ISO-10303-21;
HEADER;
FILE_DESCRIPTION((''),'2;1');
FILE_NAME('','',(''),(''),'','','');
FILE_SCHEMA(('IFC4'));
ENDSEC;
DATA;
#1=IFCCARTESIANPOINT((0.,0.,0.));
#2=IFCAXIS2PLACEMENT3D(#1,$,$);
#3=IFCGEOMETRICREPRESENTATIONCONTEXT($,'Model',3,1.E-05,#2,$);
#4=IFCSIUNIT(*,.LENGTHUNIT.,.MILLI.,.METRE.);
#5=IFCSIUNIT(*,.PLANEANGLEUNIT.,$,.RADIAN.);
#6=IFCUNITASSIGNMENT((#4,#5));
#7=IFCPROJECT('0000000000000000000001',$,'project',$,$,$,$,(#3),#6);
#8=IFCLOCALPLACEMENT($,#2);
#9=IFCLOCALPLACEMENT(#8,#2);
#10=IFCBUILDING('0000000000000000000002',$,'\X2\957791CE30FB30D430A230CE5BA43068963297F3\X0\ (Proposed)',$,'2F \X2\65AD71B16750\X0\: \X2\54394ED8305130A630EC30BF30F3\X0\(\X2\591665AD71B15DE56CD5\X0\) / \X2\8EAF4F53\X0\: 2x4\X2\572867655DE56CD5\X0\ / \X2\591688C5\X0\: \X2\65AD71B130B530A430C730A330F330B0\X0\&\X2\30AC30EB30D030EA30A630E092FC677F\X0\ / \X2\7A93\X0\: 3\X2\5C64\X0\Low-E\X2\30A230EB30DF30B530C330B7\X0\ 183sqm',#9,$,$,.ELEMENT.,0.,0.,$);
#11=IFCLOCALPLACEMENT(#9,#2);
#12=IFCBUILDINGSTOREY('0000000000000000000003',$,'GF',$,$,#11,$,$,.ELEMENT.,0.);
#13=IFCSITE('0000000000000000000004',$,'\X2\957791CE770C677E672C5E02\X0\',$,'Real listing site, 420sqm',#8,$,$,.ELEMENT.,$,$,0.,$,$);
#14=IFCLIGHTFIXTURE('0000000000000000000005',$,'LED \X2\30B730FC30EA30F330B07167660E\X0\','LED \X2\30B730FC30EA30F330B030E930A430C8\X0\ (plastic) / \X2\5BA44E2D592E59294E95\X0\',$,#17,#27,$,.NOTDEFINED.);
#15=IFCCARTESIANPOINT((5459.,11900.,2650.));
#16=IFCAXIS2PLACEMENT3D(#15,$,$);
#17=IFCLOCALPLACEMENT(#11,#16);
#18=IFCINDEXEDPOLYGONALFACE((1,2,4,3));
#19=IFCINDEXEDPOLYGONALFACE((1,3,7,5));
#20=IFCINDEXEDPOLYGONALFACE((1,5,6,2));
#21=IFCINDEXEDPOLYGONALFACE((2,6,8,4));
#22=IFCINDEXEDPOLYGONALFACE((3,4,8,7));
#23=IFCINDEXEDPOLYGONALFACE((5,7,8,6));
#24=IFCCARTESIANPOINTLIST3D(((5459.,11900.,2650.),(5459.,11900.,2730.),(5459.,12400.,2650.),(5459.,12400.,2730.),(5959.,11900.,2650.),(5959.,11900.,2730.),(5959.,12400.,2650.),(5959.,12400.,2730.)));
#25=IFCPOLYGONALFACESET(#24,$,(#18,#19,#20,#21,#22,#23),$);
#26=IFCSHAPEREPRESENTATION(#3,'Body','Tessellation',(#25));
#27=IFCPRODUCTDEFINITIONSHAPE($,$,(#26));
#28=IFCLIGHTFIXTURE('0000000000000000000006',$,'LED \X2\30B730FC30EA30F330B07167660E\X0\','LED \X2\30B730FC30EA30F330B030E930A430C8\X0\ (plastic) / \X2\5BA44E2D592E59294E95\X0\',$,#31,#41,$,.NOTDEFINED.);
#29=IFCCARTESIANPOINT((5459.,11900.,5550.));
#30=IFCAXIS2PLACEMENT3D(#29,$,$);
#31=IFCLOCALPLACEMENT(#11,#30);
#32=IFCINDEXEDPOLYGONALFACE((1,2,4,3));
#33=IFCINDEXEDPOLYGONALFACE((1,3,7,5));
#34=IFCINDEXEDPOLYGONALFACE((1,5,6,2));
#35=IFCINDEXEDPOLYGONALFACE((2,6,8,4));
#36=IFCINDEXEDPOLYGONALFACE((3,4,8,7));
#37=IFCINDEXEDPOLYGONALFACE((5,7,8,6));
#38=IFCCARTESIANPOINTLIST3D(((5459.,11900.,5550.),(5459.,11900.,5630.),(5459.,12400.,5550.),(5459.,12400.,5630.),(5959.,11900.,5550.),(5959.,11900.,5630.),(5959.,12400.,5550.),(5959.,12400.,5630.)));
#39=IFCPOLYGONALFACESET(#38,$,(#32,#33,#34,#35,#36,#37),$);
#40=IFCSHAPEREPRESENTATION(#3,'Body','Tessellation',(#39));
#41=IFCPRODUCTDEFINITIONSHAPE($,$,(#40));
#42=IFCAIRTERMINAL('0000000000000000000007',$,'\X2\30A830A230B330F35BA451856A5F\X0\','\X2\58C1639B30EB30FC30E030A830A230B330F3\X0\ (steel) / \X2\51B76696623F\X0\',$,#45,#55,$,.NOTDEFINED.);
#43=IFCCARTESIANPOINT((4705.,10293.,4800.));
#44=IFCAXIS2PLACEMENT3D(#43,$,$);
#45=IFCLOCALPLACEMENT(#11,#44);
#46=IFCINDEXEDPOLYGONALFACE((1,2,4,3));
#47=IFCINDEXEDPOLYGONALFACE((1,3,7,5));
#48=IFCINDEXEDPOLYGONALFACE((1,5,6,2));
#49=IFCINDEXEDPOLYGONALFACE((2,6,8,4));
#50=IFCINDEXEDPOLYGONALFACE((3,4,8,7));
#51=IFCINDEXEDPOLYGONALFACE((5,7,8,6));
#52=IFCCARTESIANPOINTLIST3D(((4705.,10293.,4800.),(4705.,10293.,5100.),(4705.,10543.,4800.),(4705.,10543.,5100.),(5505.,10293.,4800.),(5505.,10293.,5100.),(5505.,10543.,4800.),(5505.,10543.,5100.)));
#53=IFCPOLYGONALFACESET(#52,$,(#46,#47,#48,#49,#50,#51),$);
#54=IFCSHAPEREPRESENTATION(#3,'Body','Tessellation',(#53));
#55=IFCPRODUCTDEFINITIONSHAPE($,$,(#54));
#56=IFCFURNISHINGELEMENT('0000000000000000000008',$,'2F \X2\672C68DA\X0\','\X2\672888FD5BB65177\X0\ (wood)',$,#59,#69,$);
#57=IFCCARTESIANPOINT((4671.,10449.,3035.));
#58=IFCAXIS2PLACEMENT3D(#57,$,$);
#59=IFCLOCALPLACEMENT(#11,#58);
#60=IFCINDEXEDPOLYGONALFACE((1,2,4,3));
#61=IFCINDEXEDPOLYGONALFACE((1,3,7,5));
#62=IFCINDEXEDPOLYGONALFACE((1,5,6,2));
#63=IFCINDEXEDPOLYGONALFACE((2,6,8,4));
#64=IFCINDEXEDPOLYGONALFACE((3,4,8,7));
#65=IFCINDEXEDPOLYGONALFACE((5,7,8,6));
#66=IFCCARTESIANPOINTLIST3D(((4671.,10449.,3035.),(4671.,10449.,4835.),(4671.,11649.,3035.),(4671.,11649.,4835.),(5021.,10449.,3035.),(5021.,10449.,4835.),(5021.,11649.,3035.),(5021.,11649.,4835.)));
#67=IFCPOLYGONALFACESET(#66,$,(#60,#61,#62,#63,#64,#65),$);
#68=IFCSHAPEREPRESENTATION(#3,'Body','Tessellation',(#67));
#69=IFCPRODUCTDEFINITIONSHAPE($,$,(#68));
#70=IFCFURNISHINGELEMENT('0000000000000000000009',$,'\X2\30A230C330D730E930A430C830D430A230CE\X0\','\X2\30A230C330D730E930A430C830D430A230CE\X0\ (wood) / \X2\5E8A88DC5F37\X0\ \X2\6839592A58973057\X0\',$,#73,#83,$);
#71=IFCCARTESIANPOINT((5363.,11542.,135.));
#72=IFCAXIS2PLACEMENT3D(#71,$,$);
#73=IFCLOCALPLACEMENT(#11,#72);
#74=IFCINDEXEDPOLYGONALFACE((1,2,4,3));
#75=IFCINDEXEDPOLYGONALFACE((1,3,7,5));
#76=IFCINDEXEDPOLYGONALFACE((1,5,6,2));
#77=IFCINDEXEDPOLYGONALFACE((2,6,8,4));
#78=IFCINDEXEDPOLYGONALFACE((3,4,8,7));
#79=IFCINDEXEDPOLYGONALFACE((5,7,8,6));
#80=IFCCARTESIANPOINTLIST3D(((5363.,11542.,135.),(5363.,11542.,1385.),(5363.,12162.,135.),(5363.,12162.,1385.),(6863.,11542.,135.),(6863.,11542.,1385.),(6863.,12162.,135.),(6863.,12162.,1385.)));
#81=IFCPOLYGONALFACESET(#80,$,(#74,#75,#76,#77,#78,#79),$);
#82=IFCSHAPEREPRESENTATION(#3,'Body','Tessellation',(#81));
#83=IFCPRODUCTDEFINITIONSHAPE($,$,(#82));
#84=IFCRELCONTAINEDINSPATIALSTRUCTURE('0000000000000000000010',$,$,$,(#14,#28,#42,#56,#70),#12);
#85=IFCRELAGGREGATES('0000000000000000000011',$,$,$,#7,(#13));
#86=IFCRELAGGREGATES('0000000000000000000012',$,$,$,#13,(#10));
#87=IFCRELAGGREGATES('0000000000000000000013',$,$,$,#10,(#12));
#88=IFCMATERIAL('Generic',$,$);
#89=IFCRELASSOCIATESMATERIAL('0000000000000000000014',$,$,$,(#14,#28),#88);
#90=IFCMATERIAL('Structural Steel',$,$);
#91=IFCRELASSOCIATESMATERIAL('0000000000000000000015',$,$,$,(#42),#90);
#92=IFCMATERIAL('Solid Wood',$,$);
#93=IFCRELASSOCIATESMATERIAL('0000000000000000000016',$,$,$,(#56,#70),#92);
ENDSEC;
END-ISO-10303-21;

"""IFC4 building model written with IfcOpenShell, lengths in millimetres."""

from ifc_helpers import new_model, si_unit, frame, frame_2d, origin, place, context, project, spatial, rectangle, extrude, material, element, save


model = new_model("IFC4")

# Units and contexts
model_context = context("Model", 3, precision=1e-05, world=origin())
ifc_project = project(units=[si_unit("LENGTHUNIT", "METRE", prefix="MILLI"), si_unit("PLANEANGLEUNIT", "RADIAN")], contexts=[model_context])

# Site, building, storey
site_placement = place(None, origin())
site = spatial("IfcSite", under=ifc_project, at=site_placement, Name="長野県松本市", ObjectType="Real listing site, 420sqm", CompositionType="ELEMENT", RefElevation=0.0)
building_placement = place(site_placement, origin())
building = spatial("IfcBuilding", under=site, at=building_placement, Name="長野・ピアノ室と防音 (Proposed)", ObjectType="2F 断熱材: 吹付けウレタン(外断熱工法) / 躯体: 2x4在来工法 / 外装: 断熱サイディング&ガルバリウム鋼板 / 窓: 3層Low-Eアルミサッシ 183sqm", CompositionType="ELEMENT", ElevationOfRefHeight=0.0, ElevationOfTerrain=0.0)
storey_placement = place(building_placement, origin())
storey = spatial("IfcBuildingStorey", under=building, at=storey_placement, Name="GF", CompositionType="ELEMENT", Elevation=0.0)

# Shared definitions
ifc_material_1 = material(Name="Solid Wood")

# Shared definitions
ifc_material_2 = material(Name="Structural Steel")

# Shared definitions
ifc_material_3 = material(Name="Generic")

# Light fixtures
light_fixture_1_placement = place(storey_placement, frame((5459.0, 11900.0, 2650.0)))
element("IfcLightFixture", 1, at=light_fixture_1_placement, inside=storey, material=ifc_material_3, Name="LED シーリング照明", Description="LED シーリングライト (plastic) / 室中央天井", PredefinedType="NOTDEFINED", context=model_context, shape_type="SweptSolid", body=[
    extrude(rectangle(XDim=500.0, YDim=500.0, at=frame_2d((250.0, 250.0))), frame((5459.0, 11900.0, 2650.0)), (0.0, 0.0, 1.0), 80.0),
])
light_fixture_2_placement = place(storey_placement, frame((5459.0, 11900.0, 5550.0)))
element("IfcLightFixture", 2, at=light_fixture_2_placement, inside=storey, material=ifc_material_3, Name="LED シーリング照明", Description="LED シーリングライト (plastic) / 室中央天井", PredefinedType="NOTDEFINED", context=model_context, shape_type="SweptSolid", body=[
    extrude(rectangle(XDim=500.0, YDim=500.0, at=frame_2d((250.0, 250.0))), frame((5459.0, 11900.0, 5550.0)), (0.0, 0.0, 1.0), 80.0),
])

# Air terminal
air_terminal_placement = place(storey_placement, frame((4705.0, 10293.0, 4800.0)))
element("IfcAirTerminal", 3, at=air_terminal_placement, inside=storey, material=ifc_material_2, Name="エアコン室内機", Description="壁掛ルームエアコン (steel) / 冷暖房", PredefinedType="NOTDEFINED", context=model_context, shape_type="SweptSolid", body=[
    extrude(rectangle(XDim=800.0, YDim=250.0, at=frame_2d((400.0, 125.0))), frame((4705.0, 10293.0, 4800.0)), (0.0, 0.0, 1.0), 300.0),
])

# Furnishing elements
furnishing_1_placement = place(storey_placement, frame((4671.0, 10449.0, 3035.0)))
element("IfcFurnishingElement", 4, at=furnishing_1_placement, inside=storey, material=ifc_material_1, Name="2F 本棚", Description="木製家具 (wood)", context=model_context, shape_type="SweptSolid", body=[
    extrude(rectangle(XDim=350.0, YDim=1200.0, at=frame_2d((175.0, 600.0))), frame((4671.0, 10449.0, 3035.0)), (0.0, 0.0, 1.0), 1800.0),
])
furnishing_2_placement = place(storey_placement, frame((5363.0, 11542.0, 135.0)))
element("IfcFurnishingElement", 5, at=furnishing_2_placement, inside=storey, material=ifc_material_1, Name="アップライトピアノ", Description="アップライトピアノ (wood) / 床補強 根太増し", context=model_context, shape_type="SweptSolid", body=[
    extrude(rectangle(XDim=1500.0, YDim=620.0, at=frame_2d((750.0, 310.0))), frame((5363.0, 11542.0, 135.0)), (0.0, 0.0, 1.0), 1250.0),
])

save(model, "model.ifc")
